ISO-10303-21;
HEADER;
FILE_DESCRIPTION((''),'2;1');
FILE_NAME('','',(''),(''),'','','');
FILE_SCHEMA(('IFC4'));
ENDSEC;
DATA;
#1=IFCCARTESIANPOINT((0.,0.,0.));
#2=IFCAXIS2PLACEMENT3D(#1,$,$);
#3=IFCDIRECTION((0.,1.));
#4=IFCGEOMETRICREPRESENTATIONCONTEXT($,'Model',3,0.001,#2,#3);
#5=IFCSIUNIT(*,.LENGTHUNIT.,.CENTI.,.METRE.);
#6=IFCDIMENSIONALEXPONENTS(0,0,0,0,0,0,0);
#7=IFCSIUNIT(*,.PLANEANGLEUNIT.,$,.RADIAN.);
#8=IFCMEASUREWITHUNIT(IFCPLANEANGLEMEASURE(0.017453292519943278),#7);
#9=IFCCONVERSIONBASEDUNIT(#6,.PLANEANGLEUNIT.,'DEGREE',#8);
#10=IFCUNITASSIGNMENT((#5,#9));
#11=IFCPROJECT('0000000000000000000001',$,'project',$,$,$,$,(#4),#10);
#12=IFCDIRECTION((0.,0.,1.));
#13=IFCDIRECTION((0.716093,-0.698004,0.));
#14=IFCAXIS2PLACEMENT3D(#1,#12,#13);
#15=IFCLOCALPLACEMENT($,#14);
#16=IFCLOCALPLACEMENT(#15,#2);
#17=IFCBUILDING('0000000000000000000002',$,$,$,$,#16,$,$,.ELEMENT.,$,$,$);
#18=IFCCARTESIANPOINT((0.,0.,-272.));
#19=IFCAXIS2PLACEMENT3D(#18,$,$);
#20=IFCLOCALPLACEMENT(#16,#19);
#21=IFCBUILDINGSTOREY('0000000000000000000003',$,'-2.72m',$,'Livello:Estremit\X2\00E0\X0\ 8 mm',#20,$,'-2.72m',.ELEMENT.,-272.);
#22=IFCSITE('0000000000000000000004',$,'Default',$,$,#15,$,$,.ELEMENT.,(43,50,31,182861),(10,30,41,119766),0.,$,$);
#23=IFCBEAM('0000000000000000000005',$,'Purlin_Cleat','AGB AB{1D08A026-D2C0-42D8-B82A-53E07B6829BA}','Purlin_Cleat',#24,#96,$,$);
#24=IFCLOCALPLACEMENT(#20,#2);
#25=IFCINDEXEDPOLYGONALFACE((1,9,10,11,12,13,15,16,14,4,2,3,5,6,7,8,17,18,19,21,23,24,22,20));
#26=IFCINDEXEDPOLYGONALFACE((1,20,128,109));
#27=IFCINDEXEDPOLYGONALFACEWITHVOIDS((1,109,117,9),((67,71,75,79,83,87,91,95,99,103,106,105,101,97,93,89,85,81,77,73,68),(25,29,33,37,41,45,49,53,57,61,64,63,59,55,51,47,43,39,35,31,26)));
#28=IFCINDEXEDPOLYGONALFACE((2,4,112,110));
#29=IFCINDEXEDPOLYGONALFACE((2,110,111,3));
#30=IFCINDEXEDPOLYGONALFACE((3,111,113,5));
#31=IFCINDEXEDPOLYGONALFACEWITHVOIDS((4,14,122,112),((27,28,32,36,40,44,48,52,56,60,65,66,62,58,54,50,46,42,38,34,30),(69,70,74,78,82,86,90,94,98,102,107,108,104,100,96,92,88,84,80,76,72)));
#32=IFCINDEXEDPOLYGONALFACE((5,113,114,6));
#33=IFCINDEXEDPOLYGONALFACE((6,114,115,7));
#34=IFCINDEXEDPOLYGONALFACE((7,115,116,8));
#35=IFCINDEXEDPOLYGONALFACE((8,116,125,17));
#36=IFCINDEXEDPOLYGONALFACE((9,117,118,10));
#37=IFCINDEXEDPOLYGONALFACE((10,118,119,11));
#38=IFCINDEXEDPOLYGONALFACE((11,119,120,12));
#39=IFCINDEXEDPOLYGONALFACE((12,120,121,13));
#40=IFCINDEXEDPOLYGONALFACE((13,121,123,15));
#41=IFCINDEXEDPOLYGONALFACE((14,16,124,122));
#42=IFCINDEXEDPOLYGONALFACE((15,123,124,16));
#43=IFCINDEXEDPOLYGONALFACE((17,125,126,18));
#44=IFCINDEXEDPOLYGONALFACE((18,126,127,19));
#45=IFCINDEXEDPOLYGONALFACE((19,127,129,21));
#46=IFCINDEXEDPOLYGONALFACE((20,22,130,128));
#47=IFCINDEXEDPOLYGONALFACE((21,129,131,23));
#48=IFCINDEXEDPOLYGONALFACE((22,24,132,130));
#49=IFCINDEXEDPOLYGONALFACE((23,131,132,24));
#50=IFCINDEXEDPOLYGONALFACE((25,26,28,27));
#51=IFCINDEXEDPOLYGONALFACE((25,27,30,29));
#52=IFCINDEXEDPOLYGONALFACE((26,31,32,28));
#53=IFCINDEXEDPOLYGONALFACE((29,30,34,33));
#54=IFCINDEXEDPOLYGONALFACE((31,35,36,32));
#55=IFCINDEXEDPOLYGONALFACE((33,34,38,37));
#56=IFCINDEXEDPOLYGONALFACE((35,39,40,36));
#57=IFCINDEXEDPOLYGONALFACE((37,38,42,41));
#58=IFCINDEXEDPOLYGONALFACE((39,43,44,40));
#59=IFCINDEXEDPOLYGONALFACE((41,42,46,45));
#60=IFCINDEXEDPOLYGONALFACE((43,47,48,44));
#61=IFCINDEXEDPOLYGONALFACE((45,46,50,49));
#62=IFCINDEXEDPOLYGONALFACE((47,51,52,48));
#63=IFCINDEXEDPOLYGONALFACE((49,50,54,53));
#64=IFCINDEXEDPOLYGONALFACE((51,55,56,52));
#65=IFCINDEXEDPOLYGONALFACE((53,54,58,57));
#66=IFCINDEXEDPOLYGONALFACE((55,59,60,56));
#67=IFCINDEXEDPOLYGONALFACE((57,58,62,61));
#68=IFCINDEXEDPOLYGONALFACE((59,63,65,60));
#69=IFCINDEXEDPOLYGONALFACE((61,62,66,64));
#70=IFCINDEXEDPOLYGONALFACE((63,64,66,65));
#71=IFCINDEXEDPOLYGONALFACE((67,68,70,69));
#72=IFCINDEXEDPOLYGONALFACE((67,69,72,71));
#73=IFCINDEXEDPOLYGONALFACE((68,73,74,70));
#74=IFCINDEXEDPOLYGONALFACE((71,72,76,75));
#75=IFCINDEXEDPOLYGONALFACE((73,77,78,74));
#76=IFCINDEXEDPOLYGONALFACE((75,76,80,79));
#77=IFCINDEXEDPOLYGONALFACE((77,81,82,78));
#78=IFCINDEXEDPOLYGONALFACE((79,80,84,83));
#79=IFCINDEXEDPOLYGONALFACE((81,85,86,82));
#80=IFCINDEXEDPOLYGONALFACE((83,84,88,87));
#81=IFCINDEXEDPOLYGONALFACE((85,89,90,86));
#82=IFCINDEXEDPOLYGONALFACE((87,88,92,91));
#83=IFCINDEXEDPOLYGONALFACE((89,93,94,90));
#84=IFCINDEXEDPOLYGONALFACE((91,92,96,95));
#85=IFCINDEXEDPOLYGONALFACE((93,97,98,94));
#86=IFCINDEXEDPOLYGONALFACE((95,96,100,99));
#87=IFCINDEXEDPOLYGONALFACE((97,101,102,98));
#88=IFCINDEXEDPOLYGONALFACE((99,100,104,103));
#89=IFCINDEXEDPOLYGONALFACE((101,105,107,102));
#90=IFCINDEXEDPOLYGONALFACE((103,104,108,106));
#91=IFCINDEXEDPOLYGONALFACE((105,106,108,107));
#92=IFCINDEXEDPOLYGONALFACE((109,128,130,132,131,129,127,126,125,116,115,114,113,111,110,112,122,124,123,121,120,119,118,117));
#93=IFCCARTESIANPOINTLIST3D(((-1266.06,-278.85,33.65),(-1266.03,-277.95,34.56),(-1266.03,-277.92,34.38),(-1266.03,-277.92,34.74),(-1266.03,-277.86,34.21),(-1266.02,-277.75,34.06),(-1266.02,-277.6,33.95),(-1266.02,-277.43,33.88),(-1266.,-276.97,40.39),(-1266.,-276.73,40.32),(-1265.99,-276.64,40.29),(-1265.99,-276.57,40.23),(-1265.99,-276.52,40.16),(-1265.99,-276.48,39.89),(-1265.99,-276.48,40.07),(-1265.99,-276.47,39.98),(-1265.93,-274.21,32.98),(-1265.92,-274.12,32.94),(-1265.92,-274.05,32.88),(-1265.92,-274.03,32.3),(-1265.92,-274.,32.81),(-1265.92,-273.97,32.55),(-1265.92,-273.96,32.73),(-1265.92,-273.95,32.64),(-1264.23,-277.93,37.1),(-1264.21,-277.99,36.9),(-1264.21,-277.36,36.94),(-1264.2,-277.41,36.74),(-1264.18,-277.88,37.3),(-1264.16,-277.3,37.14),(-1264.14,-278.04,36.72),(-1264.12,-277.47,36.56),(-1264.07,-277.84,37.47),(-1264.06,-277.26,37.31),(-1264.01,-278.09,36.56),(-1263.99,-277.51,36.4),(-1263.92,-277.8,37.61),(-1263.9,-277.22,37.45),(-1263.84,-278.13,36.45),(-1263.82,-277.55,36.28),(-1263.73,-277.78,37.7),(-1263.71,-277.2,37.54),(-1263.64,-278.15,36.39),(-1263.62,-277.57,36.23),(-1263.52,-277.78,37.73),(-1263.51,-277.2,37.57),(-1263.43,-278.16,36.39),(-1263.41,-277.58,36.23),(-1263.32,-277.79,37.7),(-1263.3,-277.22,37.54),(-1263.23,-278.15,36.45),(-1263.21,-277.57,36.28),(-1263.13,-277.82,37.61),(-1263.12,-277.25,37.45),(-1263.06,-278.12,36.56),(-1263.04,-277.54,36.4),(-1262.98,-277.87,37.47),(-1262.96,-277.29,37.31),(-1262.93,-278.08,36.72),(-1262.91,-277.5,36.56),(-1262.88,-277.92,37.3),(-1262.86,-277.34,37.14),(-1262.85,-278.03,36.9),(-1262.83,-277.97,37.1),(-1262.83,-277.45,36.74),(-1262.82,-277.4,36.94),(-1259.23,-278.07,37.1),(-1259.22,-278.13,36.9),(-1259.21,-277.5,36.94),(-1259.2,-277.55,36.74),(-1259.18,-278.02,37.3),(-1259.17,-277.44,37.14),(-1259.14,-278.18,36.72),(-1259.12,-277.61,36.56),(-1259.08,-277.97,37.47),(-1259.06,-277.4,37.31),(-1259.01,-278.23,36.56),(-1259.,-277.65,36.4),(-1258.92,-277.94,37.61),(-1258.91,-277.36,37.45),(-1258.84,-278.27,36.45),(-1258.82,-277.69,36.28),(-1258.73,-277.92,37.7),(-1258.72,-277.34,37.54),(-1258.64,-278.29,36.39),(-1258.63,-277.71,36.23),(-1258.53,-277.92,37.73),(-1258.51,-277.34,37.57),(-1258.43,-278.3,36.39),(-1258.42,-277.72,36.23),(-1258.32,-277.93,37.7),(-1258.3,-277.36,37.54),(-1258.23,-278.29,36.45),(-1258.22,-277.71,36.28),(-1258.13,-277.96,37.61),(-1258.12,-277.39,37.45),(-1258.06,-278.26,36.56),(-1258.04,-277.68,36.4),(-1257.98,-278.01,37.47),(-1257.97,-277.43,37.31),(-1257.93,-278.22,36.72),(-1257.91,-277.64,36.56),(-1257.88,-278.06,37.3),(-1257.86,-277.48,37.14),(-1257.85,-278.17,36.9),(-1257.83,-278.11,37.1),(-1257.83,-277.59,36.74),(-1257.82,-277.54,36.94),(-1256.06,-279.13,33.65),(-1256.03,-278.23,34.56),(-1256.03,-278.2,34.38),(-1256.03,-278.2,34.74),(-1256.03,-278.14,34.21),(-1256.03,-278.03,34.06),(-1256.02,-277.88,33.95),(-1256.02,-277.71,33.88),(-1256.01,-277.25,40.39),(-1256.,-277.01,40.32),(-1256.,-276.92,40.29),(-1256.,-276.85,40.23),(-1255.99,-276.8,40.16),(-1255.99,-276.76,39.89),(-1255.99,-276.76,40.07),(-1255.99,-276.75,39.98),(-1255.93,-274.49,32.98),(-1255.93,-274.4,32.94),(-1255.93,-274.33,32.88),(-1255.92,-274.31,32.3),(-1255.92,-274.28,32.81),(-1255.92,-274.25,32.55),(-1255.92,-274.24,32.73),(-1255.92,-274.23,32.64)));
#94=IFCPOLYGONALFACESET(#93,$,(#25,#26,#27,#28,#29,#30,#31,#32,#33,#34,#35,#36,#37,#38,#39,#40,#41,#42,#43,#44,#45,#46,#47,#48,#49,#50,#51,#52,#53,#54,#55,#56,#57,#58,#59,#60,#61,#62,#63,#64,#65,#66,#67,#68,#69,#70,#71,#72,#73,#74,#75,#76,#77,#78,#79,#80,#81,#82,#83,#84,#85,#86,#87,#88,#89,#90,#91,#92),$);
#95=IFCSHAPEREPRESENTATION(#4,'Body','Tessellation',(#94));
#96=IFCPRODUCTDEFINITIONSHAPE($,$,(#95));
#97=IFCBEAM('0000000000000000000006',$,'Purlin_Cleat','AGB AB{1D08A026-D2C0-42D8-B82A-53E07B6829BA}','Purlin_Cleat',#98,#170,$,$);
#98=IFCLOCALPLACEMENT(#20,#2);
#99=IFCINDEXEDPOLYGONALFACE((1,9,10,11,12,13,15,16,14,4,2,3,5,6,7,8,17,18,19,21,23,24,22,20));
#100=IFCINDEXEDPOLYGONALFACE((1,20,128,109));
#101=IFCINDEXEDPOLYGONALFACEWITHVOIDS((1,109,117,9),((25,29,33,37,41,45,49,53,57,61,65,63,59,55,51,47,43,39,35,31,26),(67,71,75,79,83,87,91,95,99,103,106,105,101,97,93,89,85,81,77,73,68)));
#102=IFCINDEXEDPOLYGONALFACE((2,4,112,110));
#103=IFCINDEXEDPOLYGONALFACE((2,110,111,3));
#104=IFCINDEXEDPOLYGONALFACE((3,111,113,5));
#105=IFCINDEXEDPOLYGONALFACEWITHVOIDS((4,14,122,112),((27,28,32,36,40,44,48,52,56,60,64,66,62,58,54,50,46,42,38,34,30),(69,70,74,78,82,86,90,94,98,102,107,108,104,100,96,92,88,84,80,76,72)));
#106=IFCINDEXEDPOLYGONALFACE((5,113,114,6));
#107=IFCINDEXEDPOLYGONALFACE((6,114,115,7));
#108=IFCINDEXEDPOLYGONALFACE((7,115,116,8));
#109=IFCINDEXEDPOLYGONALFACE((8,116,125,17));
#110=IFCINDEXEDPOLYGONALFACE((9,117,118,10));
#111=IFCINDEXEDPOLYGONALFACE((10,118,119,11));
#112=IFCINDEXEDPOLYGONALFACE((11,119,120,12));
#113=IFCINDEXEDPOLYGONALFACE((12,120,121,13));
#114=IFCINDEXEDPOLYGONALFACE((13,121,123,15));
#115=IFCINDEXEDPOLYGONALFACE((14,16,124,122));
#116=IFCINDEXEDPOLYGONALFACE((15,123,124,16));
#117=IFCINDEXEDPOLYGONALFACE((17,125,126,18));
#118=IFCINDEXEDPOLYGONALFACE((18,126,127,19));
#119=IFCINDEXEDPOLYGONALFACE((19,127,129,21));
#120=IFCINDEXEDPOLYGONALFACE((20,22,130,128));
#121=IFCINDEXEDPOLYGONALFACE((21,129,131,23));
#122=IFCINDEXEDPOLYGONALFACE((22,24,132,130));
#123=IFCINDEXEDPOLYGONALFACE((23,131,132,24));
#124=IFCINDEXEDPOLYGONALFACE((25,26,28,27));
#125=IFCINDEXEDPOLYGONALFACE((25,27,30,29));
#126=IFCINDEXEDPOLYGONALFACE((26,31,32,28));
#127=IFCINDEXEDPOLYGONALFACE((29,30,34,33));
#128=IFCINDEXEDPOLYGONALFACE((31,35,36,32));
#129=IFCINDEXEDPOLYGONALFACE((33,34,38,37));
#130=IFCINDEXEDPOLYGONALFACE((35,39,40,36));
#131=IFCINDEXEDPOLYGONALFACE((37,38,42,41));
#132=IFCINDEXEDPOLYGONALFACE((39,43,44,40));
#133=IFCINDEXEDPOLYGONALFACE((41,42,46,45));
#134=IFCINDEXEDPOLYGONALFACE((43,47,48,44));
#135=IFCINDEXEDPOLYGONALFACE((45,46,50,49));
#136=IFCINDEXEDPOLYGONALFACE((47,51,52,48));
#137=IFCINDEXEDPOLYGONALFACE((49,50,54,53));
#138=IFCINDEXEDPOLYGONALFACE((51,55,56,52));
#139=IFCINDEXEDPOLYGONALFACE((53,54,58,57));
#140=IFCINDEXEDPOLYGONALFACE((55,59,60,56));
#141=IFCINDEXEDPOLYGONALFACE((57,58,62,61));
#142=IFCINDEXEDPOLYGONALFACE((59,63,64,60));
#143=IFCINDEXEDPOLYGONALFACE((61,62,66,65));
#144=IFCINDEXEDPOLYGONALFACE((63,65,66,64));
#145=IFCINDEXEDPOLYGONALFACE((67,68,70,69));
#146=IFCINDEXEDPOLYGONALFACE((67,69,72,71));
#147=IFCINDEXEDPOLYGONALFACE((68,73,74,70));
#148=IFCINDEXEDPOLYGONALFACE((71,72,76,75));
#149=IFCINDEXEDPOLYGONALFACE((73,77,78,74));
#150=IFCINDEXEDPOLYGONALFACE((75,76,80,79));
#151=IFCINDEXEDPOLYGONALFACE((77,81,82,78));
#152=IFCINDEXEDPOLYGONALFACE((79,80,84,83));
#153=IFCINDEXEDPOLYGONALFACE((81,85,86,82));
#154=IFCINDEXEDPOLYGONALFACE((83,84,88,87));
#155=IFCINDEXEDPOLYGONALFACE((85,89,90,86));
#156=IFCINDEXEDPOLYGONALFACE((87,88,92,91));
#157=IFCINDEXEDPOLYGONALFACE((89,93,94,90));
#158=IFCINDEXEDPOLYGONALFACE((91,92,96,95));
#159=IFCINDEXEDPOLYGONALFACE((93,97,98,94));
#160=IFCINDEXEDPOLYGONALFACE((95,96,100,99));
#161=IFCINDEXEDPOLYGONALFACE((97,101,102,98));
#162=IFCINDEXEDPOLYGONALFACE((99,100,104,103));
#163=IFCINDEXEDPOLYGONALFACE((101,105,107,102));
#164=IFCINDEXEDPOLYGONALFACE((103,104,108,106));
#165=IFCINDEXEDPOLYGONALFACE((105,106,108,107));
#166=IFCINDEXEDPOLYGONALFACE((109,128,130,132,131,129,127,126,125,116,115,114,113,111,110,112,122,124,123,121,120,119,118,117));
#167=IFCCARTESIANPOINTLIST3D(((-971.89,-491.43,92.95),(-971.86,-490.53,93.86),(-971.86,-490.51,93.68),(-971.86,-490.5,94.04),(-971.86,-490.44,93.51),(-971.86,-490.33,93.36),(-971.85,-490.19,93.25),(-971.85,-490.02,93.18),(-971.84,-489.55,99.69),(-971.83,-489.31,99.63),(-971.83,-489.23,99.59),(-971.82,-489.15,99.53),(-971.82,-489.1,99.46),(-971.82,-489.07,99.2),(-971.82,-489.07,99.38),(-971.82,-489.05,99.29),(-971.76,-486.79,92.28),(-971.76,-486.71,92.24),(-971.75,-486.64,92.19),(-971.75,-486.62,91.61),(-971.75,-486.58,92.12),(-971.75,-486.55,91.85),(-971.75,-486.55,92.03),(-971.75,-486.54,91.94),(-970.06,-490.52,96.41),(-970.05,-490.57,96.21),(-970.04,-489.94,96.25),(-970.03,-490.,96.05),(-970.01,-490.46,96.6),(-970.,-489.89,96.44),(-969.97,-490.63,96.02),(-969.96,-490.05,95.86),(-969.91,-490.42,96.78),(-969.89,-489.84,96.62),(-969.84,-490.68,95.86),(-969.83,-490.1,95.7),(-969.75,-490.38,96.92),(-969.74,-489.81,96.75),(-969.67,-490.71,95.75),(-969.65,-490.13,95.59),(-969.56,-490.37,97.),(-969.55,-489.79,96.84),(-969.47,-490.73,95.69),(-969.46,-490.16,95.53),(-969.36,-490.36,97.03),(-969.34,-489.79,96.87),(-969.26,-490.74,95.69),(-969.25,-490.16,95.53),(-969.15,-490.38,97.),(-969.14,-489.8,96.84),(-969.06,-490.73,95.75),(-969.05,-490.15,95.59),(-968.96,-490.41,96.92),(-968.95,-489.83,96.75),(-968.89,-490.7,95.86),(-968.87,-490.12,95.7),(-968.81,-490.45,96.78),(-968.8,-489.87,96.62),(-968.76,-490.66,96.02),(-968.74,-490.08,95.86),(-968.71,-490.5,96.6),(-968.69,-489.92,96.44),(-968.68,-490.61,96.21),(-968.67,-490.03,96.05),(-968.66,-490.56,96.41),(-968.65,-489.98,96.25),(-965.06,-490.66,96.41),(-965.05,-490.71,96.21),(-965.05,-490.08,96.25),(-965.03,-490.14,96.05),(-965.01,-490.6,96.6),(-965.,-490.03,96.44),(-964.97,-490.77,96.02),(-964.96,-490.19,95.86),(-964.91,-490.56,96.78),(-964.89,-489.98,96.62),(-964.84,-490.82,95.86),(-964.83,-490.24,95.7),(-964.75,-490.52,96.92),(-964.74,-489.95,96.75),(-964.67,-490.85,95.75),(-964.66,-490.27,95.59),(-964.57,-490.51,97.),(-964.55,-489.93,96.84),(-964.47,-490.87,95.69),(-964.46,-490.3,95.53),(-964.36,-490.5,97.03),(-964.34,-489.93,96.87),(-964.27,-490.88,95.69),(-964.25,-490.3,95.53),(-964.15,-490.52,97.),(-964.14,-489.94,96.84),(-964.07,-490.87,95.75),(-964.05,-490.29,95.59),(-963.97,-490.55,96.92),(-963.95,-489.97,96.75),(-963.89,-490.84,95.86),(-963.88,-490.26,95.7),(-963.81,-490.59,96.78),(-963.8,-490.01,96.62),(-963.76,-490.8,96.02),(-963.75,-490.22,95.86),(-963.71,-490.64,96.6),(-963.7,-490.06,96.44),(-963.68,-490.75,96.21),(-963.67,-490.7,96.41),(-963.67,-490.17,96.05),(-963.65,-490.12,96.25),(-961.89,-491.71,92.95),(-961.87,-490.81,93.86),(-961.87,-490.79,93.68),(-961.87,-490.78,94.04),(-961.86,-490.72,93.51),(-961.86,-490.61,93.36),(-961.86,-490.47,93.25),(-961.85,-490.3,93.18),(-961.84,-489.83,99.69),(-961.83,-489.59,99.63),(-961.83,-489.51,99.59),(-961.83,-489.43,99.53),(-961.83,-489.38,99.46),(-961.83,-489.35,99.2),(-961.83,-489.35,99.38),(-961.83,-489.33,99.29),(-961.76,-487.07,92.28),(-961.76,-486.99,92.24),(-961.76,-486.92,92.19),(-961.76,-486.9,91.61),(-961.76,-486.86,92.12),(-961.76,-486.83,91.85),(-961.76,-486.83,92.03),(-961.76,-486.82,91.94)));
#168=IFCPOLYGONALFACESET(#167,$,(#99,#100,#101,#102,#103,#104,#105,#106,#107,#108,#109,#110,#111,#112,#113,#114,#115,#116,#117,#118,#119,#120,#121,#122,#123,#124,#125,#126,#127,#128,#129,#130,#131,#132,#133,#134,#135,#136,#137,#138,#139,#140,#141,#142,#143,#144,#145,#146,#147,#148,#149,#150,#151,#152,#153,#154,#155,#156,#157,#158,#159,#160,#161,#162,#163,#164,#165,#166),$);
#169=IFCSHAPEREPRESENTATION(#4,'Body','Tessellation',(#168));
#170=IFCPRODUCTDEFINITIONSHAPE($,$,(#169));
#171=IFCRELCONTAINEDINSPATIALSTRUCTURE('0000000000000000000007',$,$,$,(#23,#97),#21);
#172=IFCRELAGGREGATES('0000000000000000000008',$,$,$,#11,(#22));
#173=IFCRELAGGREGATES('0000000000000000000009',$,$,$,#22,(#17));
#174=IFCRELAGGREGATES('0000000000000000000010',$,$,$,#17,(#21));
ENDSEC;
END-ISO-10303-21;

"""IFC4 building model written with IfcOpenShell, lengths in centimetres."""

from ifc_helpers import new_model, entity, si_unit, converted_unit, direction, frame, frame_2d, origin, place, context, project, spatial, circle, l_section, extrude, element, save


model = new_model("IFC4")

# Units and contexts
model_context = context("Model", 3, precision=0.001, world=origin(), true_north=direction((0.0, 1.0)))
ifc_project = project(units=[si_unit("LENGTHUNIT", "METRE", prefix="CENTI"), converted_unit("PLANEANGLEUNIT", "DEGREE", entity("IfcPlaneAngleMeasure", 0.017453292519943278), si_unit("PLANEANGLEUNIT", "RADIAN"), dimensions=[0, 0, 0, 0, 0, 0, 0])], contexts=[model_context])

# Site, building, storey
site_placement = place(None, frame((0.0, 0.0, 0.0), z_axis=(0.0, 0.0, 1.0), x_axis=(0.716093, -0.698004, 0.0)))
site = spatial("IfcSite", under=ifc_project, at=site_placement, Name="Default", CompositionType="ELEMENT", RefLatitude=(43, 50, 31, 182861), RefLongitude=(10, 30, 41, 119766), RefElevation=0.0)
building_placement = place(site_placement, origin())
building = spatial("IfcBuilding", under=site, at=building_placement, CompositionType="ELEMENT")
storey_placement = place(building_placement, frame((0.0, 0.0, -272.0)))
storey = spatial("IfcBuildingStorey", under=building, at=storey_placement, Name="-2.72m", ObjectType="Livello:Estremità 8 mm", LongName="-2.72m", CompositionType="ELEMENT", Elevation=-272.0)

# Beams, openings
beam_1_placement = place(storey_placement, frame((-1256.01, -277.34, 35.48), z_axis=(-0.999608, 0.02798, 0.0), x_axis=(0.007515, 0.268478, 0.963256)))
beam_1 = element("IfcBeam", 1, at=beam_1_placement, inside=storey, Name="Purlin_Cleat", Description="AGB AB{1D08A026-D2C0-42D8-B82A-53E07B6829BA}", ObjectType="Purlin_Cleat", context=model_context, shape_type="SweptSolid", body=[
    extrude(l_section(Depth=5.0, Width=7.0, Thickness=0.6, FilletRadius=0.7, EdgeRadius=0.35, at=frame_2d((1.25, 1.27))), origin(), (0.0, 0.0, 1.0), 10.0),
])
opening_1_placement = place(beam_1_placement, frame((1.29, -1.3, 6.8), z_axis=(0.0, -1.0, 0.0), x_axis=(1.0, 0.0, 0.0)))
element("IfcOpeningElement", 2, at=opening_1_placement, cuts=beam_1, ObjectType="Opening", context=model_context, shape_type="SweptSolid", body=[
    extrude(circle(Radius=0.7, at=frame_2d((0.0, 0.7), x_axis=(1.0, 0.0))), origin(), (0.0, 0.0, -1.0), 0.7),
])
opening_2_placement = place(beam_1_placement, frame((1.29, -1.3, 1.8), z_axis=(0.0, -1.0, 0.0), x_axis=(1.0, 0.0, 0.0)))
element("IfcOpeningElement", 3, at=opening_2_placement, cuts=beam_1, ObjectType="Opening", context=model_context, shape_type="SweptSolid", body=[
    extrude(circle(Radius=0.7, at=frame_2d((0.0, 0.7), x_axis=(1.0, 0.0))), origin(), (0.0, 0.0, -1.0), 0.7),
])
beam_2_placement = place(storey_placement, frame((-961.84, -489.92, 94.79), z_axis=(-0.999608, 0.02798, 0.0), x_axis=(0.007515, 0.268478, 0.963256)))
beam_2 = element("IfcBeam", 4, at=beam_2_placement, inside=storey, Name="Purlin_Cleat", Description="AGB AB{1D08A026-D2C0-42D8-B82A-53E07B6829BA}", ObjectType="Purlin_Cleat", context=model_context, shape_type="SweptSolid", body=[
    extrude(l_section(Depth=5.0, Width=7.0, Thickness=0.6, FilletRadius=0.7, EdgeRadius=0.35, at=frame_2d((1.25, 1.27))), origin(), (0.0, 0.0, 1.0), 10.0),
])
opening_3_placement = place(beam_2_placement, frame((1.29, -1.3, 6.8), z_axis=(0.0, -1.0, 0.0), x_axis=(1.0, 0.0, 0.0)))
element("IfcOpeningElement", 5, at=opening_3_placement, cuts=beam_2, ObjectType="Opening", context=model_context, shape_type="SweptSolid", body=[
    extrude(circle(Radius=0.7, at=frame_2d((0.0, 0.7), x_axis=(1.0, 0.0))), origin(), (0.0, 0.0, -1.0), 0.7),
])
opening_4_placement = place(beam_2_placement, frame((1.29, -1.3, 1.8), z_axis=(0.0, -1.0, 0.0), x_axis=(1.0, 0.0, 0.0)))
element("IfcOpeningElement", 6, at=opening_4_placement, cuts=beam_2, ObjectType="Opening", context=model_context, shape_type="SweptSolid", body=[
    extrude(circle(Radius=0.7, at=frame_2d((0.0, 0.7), x_axis=(1.0, 0.0))), origin(), (0.0, 0.0, -1.0), 0.7),
])

save(model, "model.ifc")
